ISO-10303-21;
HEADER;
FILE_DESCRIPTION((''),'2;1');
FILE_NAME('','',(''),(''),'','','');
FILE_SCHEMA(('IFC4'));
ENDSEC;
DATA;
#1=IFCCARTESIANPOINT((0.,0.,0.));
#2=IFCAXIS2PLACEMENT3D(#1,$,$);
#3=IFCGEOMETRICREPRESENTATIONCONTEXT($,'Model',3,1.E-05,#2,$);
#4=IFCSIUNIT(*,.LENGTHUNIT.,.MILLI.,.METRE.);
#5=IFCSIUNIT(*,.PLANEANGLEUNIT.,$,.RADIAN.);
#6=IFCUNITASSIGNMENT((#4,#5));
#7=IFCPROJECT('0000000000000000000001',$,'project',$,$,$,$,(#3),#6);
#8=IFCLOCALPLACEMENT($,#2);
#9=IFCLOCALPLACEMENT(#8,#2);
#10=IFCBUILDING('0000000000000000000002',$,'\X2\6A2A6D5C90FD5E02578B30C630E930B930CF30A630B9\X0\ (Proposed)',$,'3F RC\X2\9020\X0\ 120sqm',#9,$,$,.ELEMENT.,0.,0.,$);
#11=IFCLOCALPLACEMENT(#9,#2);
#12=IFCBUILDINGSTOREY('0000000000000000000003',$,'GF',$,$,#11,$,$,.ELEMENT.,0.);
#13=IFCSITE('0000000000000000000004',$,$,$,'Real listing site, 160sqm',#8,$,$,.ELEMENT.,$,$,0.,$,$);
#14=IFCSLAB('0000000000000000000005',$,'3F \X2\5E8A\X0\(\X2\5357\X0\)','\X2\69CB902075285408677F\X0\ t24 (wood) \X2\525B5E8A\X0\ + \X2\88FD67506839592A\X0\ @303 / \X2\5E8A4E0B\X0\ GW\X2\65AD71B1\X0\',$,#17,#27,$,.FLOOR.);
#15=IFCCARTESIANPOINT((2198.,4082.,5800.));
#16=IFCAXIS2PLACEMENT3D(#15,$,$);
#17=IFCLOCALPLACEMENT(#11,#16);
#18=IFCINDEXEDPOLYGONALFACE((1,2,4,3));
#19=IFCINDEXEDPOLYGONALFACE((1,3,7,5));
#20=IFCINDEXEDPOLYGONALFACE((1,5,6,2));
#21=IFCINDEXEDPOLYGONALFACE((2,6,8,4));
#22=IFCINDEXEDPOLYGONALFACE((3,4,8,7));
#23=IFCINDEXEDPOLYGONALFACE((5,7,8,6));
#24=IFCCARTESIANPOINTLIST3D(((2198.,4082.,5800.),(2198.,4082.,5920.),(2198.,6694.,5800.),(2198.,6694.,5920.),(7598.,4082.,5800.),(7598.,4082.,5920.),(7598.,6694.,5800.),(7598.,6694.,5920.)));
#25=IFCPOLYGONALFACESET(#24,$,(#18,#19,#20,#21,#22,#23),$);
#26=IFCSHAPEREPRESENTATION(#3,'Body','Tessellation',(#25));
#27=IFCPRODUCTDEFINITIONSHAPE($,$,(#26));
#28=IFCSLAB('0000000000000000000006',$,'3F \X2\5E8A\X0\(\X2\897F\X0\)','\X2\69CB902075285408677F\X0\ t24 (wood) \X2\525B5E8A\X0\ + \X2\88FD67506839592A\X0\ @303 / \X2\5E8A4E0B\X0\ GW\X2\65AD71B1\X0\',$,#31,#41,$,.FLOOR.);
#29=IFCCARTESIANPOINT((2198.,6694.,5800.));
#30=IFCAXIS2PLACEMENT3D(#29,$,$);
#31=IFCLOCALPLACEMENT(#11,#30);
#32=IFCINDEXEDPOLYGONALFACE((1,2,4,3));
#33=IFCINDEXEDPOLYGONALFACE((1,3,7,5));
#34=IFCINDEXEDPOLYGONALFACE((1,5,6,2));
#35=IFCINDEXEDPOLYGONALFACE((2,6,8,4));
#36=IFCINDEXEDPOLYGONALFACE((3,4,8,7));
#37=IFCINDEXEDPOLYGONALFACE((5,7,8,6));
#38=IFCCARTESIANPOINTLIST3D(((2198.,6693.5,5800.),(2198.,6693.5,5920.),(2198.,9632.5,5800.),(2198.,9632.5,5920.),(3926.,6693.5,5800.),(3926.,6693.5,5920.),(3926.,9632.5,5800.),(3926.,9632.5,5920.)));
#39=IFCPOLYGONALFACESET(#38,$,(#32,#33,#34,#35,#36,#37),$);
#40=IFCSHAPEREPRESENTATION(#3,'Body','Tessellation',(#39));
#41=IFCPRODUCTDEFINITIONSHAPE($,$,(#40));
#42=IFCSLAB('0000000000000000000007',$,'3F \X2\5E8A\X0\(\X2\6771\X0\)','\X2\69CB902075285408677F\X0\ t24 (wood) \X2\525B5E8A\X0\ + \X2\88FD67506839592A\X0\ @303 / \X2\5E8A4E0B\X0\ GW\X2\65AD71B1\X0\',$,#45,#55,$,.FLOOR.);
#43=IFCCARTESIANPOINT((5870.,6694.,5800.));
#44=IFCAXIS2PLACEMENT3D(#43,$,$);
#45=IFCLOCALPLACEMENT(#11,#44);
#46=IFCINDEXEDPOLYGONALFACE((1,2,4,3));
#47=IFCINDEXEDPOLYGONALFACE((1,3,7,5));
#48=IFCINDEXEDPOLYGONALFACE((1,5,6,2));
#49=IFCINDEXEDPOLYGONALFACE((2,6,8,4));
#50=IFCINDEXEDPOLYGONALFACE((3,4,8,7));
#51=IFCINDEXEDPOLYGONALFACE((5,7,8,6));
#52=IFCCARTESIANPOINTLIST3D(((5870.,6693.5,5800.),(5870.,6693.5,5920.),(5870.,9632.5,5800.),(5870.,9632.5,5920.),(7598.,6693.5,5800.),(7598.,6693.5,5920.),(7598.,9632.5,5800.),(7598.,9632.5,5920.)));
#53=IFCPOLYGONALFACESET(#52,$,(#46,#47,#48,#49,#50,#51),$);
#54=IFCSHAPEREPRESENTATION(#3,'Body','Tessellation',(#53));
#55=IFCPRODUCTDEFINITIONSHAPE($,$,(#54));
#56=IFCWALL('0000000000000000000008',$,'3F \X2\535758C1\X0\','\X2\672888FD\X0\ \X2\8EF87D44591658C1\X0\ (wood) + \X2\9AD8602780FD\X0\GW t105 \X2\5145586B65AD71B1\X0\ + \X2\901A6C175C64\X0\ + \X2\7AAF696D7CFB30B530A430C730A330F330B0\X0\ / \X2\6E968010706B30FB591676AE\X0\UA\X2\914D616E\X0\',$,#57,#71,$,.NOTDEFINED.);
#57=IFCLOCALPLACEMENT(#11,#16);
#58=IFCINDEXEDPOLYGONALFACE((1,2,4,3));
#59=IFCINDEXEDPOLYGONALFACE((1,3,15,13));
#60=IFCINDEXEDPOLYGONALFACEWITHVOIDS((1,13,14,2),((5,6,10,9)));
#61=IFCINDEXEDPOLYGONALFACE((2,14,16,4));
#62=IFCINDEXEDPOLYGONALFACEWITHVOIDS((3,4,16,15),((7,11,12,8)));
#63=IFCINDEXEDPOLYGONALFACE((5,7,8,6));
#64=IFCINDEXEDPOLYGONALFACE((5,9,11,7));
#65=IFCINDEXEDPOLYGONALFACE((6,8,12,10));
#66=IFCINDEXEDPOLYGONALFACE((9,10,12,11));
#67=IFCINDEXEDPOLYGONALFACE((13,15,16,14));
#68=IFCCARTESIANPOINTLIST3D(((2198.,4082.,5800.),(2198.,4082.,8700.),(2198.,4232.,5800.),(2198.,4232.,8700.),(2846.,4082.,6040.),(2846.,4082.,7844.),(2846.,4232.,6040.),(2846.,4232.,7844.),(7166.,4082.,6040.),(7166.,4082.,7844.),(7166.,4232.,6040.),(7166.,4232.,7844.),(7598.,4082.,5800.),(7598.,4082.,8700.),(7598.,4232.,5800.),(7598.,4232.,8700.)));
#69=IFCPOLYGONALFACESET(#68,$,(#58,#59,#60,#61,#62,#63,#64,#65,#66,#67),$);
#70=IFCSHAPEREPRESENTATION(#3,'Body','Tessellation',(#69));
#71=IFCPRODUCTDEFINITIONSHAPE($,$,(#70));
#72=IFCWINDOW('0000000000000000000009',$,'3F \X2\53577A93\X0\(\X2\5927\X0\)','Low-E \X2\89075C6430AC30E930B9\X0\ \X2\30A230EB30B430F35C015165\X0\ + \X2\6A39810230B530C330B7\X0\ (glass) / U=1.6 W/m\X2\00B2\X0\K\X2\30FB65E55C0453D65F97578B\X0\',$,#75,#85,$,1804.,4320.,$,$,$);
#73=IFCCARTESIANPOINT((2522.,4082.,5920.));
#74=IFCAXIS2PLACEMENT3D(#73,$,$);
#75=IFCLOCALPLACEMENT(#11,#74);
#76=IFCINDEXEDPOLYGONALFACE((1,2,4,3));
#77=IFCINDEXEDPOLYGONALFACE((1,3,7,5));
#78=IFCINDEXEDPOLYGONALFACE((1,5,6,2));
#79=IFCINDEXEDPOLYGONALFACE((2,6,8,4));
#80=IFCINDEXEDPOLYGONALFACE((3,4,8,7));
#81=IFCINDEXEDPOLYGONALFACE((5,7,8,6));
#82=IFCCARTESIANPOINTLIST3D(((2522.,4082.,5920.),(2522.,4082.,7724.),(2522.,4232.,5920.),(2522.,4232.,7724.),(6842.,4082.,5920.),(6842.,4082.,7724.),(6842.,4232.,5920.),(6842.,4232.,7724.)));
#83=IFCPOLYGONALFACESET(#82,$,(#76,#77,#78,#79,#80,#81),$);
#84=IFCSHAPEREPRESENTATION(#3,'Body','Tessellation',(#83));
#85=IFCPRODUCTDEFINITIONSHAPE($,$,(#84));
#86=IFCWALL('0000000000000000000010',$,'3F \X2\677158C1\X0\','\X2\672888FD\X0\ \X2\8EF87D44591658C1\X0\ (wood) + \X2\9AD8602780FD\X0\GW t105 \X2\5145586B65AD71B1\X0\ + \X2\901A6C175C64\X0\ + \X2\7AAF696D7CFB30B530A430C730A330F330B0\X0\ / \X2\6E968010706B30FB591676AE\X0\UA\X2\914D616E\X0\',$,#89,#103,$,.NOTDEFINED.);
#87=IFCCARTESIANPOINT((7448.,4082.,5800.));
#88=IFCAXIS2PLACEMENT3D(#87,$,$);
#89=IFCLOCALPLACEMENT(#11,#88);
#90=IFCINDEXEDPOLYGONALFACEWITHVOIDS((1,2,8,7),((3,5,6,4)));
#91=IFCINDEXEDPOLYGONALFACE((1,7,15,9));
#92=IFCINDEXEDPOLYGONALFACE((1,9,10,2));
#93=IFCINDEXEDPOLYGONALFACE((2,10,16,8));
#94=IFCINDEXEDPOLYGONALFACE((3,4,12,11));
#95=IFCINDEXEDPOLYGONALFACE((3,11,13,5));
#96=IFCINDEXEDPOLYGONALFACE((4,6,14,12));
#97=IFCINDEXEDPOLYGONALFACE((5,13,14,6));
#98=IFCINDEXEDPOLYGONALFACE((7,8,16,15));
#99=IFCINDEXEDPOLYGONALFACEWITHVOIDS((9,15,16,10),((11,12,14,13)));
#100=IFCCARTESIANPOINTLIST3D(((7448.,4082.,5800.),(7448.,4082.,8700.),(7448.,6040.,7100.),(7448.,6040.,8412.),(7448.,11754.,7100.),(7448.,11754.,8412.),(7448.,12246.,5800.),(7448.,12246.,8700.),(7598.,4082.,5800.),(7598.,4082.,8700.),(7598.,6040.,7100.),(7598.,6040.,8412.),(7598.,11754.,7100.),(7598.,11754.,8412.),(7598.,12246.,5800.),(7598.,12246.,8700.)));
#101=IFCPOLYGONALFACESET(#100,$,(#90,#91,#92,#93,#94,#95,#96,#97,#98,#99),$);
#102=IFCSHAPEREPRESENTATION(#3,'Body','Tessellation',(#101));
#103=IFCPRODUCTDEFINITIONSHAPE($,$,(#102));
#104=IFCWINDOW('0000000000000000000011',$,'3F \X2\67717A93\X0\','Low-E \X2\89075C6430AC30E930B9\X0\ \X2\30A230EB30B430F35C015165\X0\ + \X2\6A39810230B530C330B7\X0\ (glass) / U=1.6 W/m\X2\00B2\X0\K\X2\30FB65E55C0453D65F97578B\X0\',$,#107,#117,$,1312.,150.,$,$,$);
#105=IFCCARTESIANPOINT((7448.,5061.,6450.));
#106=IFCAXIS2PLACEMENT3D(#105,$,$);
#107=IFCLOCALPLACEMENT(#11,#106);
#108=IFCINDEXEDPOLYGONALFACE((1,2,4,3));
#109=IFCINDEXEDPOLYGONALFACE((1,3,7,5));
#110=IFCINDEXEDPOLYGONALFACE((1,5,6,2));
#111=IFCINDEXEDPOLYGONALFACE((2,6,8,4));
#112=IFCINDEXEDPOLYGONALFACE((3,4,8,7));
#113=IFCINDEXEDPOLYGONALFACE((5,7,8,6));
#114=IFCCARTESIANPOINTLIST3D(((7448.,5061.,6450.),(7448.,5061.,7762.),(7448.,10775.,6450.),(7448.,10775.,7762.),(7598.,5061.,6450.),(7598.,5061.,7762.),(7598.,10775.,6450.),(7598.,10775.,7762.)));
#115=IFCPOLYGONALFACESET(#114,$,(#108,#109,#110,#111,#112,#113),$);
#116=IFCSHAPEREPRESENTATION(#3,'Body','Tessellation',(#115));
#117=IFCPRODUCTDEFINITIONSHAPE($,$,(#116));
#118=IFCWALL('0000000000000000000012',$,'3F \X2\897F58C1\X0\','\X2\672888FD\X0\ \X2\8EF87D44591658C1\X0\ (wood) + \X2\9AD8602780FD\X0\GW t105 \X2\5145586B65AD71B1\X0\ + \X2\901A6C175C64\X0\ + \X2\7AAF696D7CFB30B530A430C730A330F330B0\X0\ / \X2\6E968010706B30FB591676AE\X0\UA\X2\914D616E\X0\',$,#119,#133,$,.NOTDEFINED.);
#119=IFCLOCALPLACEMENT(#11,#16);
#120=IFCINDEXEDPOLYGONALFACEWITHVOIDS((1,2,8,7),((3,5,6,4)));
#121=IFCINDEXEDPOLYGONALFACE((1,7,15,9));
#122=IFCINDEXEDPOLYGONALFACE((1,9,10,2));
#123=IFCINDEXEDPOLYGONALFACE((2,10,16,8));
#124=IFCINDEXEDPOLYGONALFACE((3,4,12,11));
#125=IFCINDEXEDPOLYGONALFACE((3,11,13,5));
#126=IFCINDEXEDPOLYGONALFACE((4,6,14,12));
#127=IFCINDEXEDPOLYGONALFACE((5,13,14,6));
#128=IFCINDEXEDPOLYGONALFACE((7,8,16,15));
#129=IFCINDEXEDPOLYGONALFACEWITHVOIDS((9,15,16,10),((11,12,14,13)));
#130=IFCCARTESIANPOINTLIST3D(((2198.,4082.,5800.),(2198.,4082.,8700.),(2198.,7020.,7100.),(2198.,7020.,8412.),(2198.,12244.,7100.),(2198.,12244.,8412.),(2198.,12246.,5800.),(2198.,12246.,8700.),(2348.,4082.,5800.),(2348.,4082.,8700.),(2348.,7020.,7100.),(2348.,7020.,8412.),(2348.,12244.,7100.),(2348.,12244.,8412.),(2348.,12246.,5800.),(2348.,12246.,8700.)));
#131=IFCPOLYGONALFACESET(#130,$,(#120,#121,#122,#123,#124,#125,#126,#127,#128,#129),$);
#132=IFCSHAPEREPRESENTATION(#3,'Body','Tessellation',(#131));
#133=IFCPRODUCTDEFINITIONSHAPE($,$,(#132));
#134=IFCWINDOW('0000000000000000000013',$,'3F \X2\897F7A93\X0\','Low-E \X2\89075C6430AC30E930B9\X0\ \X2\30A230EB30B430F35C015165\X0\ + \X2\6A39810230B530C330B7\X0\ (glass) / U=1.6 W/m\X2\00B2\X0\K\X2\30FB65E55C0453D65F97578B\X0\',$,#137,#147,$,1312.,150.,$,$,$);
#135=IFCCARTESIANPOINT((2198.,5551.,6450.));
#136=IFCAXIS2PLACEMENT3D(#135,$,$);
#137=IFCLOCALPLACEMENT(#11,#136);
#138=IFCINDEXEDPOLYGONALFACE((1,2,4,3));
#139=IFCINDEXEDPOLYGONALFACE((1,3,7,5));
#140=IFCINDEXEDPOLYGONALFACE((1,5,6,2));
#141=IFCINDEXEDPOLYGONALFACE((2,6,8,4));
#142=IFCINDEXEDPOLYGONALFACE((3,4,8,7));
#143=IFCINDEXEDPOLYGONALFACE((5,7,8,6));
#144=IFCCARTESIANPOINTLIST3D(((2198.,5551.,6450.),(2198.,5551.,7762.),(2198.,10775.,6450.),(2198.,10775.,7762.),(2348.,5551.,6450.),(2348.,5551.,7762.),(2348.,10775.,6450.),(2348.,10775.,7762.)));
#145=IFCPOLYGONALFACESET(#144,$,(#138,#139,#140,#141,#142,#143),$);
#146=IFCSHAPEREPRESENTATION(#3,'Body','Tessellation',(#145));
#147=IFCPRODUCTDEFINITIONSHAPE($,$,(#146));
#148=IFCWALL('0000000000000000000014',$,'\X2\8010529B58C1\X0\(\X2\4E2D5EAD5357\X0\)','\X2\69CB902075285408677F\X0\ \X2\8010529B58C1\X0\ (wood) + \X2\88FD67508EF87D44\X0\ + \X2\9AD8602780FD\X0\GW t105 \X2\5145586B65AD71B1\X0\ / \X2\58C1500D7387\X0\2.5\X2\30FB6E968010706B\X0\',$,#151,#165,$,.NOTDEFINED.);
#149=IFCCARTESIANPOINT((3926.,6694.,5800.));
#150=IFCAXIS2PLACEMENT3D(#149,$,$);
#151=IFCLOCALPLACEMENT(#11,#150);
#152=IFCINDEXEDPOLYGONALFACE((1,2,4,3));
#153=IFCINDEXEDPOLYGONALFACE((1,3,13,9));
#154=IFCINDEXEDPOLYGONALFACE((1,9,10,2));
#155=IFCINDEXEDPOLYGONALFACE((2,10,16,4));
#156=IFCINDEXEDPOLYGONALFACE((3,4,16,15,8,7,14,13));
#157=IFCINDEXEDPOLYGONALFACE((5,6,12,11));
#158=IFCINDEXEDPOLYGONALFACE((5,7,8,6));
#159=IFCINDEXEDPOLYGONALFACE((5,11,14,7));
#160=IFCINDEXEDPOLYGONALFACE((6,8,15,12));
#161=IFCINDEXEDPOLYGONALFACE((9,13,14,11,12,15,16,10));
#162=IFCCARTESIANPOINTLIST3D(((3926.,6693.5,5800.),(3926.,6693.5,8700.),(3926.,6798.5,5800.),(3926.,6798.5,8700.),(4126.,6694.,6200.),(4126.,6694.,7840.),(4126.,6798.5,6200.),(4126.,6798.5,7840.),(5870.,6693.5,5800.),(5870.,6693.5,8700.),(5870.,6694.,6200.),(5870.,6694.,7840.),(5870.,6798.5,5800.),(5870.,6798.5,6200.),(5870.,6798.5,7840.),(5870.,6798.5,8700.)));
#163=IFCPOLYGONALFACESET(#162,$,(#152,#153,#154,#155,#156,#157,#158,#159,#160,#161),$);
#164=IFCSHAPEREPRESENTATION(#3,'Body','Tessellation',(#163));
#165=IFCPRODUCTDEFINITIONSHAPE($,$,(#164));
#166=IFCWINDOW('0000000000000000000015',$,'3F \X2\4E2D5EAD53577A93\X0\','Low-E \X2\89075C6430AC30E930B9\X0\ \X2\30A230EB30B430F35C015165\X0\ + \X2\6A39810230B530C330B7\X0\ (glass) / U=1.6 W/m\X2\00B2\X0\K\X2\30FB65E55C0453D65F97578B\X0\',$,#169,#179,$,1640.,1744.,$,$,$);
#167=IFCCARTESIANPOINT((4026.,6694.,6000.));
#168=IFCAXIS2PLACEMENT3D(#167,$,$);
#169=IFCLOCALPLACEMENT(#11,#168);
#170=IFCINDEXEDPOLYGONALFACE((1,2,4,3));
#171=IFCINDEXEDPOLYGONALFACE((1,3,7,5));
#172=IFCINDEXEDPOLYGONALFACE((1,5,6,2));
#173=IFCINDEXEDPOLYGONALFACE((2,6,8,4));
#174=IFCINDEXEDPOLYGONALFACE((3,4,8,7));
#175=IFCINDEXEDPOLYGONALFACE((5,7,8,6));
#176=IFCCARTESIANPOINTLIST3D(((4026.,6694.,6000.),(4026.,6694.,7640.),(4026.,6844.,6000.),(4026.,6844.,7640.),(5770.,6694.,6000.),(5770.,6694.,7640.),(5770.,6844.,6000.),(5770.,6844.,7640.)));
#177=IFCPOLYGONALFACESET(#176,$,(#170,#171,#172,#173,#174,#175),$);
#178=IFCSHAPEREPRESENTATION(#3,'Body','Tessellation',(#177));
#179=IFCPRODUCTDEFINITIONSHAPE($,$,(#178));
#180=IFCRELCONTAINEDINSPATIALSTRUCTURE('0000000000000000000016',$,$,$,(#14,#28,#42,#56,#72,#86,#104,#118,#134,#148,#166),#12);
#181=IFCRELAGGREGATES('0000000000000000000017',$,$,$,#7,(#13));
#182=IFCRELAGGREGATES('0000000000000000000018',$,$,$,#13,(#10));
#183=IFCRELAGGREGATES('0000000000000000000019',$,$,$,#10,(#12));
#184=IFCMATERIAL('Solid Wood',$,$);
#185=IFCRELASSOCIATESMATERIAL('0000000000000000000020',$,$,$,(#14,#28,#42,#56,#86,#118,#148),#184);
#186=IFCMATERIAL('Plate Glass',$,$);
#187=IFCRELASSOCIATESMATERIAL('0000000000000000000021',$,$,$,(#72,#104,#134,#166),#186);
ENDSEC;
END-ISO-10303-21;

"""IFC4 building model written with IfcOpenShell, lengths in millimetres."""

from ifc_helpers import new_model, si_unit, frame, frame_2d, origin, place, context, project, spatial, rectangle, extrude, material, element, fill, save


model = new_model("IFC4")

# Units and contexts
model_context = context("Model", 3, precision=1e-05, world=origin())
ifc_project = project(units=[si_unit("LENGTHUNIT", "METRE", prefix="MILLI"), si_unit("PLANEANGLEUNIT", "RADIAN")], contexts=[model_context])

# Site, building, storey
site_placement = place(None, origin())
site = spatial("IfcSite", under=ifc_project, at=site_placement, ObjectType="Real listing site, 160sqm", CompositionType="ELEMENT", RefElevation=0.0)
building_placement = place(site_placement, origin())
building = spatial("IfcBuilding", under=site, at=building_placement, Name="横浜都市型テラスハウス (Proposed)", ObjectType="3F RC造 120sqm", CompositionType="ELEMENT", ElevationOfRefHeight=0.0, ElevationOfTerrain=0.0)
storey_placement = place(building_placement, origin())
storey = spatial("IfcBuildingStorey", under=building, at=storey_placement, Name="GF", CompositionType="ELEMENT", Elevation=0.0)

# Slabs
ifc_material_1 = material(Name="Solid Wood")
slab_1_placement = place(storey_placement, frame((2198.0, 4082.0, 5800.0)))
element("IfcSlab", 1, at=slab_1_placement, inside=storey, material=ifc_material_1, Name="3F 床(南)", Description="構造用合板 t24 (wood) 剛床 + 製材根太 @303 / 床下 GW断熱", PredefinedType="FLOOR", context=model_context, shape_type="SweptSolid", body=[
    extrude(rectangle(XDim=5400.0, YDim=2612.0, at=frame_2d((2700.0, 1306.0))), frame((2198.0, 4082.0, 5800.0)), (0.0, 0.0, 1.0), 120.0),
])
slab_2_placement = place(storey_placement, frame((2198.0, 6694.0, 5800.0)))
element("IfcSlab", 2, at=slab_2_placement, inside=storey, material=ifc_material_1, Name="3F 床(西)", Description="構造用合板 t24 (wood) 剛床 + 製材根太 @303 / 床下 GW断熱", PredefinedType="FLOOR", context=model_context, shape_type="SweptSolid", body=[
    extrude(rectangle(XDim=1728.0, YDim=2939.0, at=frame_2d((864.0, 1469.0))), frame((2198.0, 6694.0, 5800.0)), (0.0, 0.0, 1.0), 120.0),
])
slab_3_placement = place(storey_placement, frame((5870.0, 6694.0, 5800.0)))
element("IfcSlab", 3, at=slab_3_placement, inside=storey, material=ifc_material_1, Name="3F 床(東)", Description="構造用合板 t24 (wood) 剛床 + 製材根太 @303 / 床下 GW断熱", PredefinedType="FLOOR", context=model_context, shape_type="SweptSolid", body=[
    extrude(rectangle(XDim=1728.0, YDim=2939.0, at=frame_2d((864.0, 1469.0))), frame((5870.0, 6694.0, 5800.0)), (0.0, 0.0, 1.0), 120.0),
])

# Walls, openings, windows
wall_1_placement = place(storey_placement, frame((2198.0, 4082.0, 5800.0)))
wall_1 = element("IfcWall", 4, at=wall_1_placement, inside=storey, material=ifc_material_1, Name="3F 南壁", Description="木製 軸組外壁 (wood) + 高性能GW t105 充填断熱 + 通気層 + 窯業系サイディング / 準耐火・外皮UA配慮", PredefinedType="NOTDEFINED", context=model_context, shape_type="SweptSolid", body=[
    extrude(rectangle(XDim=5400.0, YDim=150.0, at=frame_2d((2700.0, 75.0))), frame((2198.0, 4082.0, 5800.0)), (0.0, 0.0, 1.0), 2900.0),
])
opening_1_placement = place(storey_placement, frame((2522.0, 4082.0, 5920.0)))
opening_1 = element("IfcOpeningElement", 5, at=opening_1_placement, cuts=wall_1, PredefinedType="NOTDEFINED", context=model_context, shape_type="SweptSolid", body=[
    extrude(rectangle(XDim=4320.0, YDim=150.0, at=frame_2d((2160.0, 75.0))), frame((2522.0, 4082.0, 5920.0)), (0.0, 0.0, 1.0), 1804.0),
])
ifc_material_2 = material(Name="Plate Glass")
window_1_placement = place(storey_placement, frame((2522.0, 4082.0, 5920.0)))
window_1 = element("IfcWindow", 6, at=window_1_placement, inside=storey, material=ifc_material_2, Name="3F 南窓(大)", Description="Low-E 複層ガラス アルゴン封入 + 樹脂サッシ (glass) / U=1.6 W/m²K・日射取得型", OverallHeight=1804.0, OverallWidth=4320.0, context=model_context, shape_type="SweptSolid", body=[
    extrude(rectangle(XDim=4320.0, YDim=150.0, at=frame_2d((2160.0, 75.0))), frame((2522.0, 4082.0, 5920.0)), (0.0, 0.0, 1.0), 1804.0),
])
fill(opening_1, window_1)
wall_2_placement = place(storey_placement, frame((7448.0, 4082.0, 5800.0)))
wall_2 = element("IfcWall", 7, at=wall_2_placement, inside=storey, material=ifc_material_1, Name="3F 東壁", Description="木製 軸組外壁 (wood) + 高性能GW t105 充填断熱 + 通気層 + 窯業系サイディング / 準耐火・外皮UA配慮", PredefinedType="NOTDEFINED", context=model_context, shape_type="SweptSolid", body=[
    extrude(rectangle(XDim=150.0, YDim=8164.0, at=frame_2d((75.0, 4082.0))), frame((7448.0, 4082.0, 5800.0)), (0.0, 0.0, 1.0), 2900.0),
])
opening_2_placement = place(storey_placement, frame((7448.0, 5061.0, 6450.0)))
opening_2 = element("IfcOpeningElement", 8, at=opening_2_placement, cuts=wall_2, PredefinedType="NOTDEFINED", context=model_context, shape_type="SweptSolid", body=[
    extrude(rectangle(XDim=150.0, YDim=5714.0, at=frame_2d((75.0, 2857.0))), frame((7448.0, 5061.0, 6450.0)), (0.0, 0.0, 1.0), 1312.0),
])
window_2_placement = place(storey_placement, frame((7448.0, 5061.0, 6450.0)))
window_2 = element("IfcWindow", 9, at=window_2_placement, inside=storey, material=ifc_material_2, Name="3F 東窓", Description="Low-E 複層ガラス アルゴン封入 + 樹脂サッシ (glass) / U=1.6 W/m²K・日射取得型", OverallHeight=1312.0, OverallWidth=150.0, context=model_context, shape_type="SweptSolid", body=[
    extrude(rectangle(XDim=150.0, YDim=5714.0, at=frame_2d((75.0, 2857.0))), frame((7448.0, 5061.0, 6450.0)), (0.0, 0.0, 1.0), 1312.0),
])
fill(opening_2, window_2)
wall_3_placement = place(storey_placement, frame((2198.0, 4082.0, 5800.0)))
wall_3 = element("IfcWall", 10, at=wall_3_placement, inside=storey, material=ifc_material_1, Name="3F 西壁", Description="木製 軸組外壁 (wood) + 高性能GW t105 充填断熱 + 通気層 + 窯業系サイディング / 準耐火・外皮UA配慮", PredefinedType="NOTDEFINED", context=model_context, shape_type="SweptSolid", body=[
    extrude(rectangle(XDim=150.0, YDim=8164.0, at=frame_2d((75.0, 4082.0))), frame((2198.0, 4082.0, 5800.0)), (0.0, 0.0, 1.0), 2900.0),
])
opening_3_placement = place(storey_placement, frame((2198.0, 5551.0, 6450.0)))
opening_3 = element("IfcOpeningElement", 11, at=opening_3_placement, cuts=wall_3, PredefinedType="NOTDEFINED", context=model_context, shape_type="SweptSolid", body=[
    extrude(rectangle(XDim=150.0, YDim=5224.0, at=frame_2d((75.0, 2612.0))), frame((2198.0, 5551.0, 6450.0)), (0.0, 0.0, 1.0), 1312.0),
])
window_3_placement = place(storey_placement, frame((2198.0, 5551.0, 6450.0)))
window_3 = element("IfcWindow", 12, at=window_3_placement, inside=storey, material=ifc_material_2, Name="3F 西窓", Description="Low-E 複層ガラス アルゴン封入 + 樹脂サッシ (glass) / U=1.6 W/m²K・日射取得型", OverallHeight=1312.0, OverallWidth=150.0, context=model_context, shape_type="SweptSolid", body=[
    extrude(rectangle(XDim=150.0, YDim=5224.0, at=frame_2d((75.0, 2612.0))), frame((2198.0, 5551.0, 6450.0)), (0.0, 0.0, 1.0), 1312.0),
])
fill(opening_3, window_3)
wall_4_placement = place(storey_placement, frame((3926.0, 6694.0, 5800.0)))
wall_4 = element("IfcWall", 13, at=wall_4_placement, inside=storey, material=ifc_material_1, Name="耐力壁(中庭南)", Description="構造用合板 耐力壁 (wood) + 製材軸組 + 高性能GW t105 充填断熱 / 壁倍率2.5・準耐火", PredefinedType="NOTDEFINED", context=model_context, shape_type="SweptSolid", body=[
    extrude(rectangle(XDim=1944.0, YDim=105.0, at=frame_2d((972.0, 52.0))), frame((3926.0, 6694.0, 5800.0)), (0.0, 0.0, 1.0), 2900.0),
])
opening_4_placement = place(storey_placement, frame((4026.0, 6694.0, 6000.0)))
opening_4 = element("IfcOpeningElement", 14, at=opening_4_placement, cuts=wall_4, PredefinedType="NOTDEFINED", context=model_context, shape_type="SweptSolid", body=[
    extrude(rectangle(XDim=1744.0, YDim=150.0, at=frame_2d((872.0, 75.0))), frame((4026.0, 6694.0, 6000.0)), (0.0, 0.0, 1.0), 1640.0),
])
window_4_placement = place(storey_placement, frame((4026.0, 6694.0, 6000.0)))
window_4 = element("IfcWindow", 15, at=window_4_placement, inside=storey, material=ifc_material_2, Name="3F 中庭南窓", Description="Low-E 複層ガラス アルゴン封入 + 樹脂サッシ (glass) / U=1.6 W/m²K・日射取得型", OverallHeight=1640.0, OverallWidth=1744.0, context=model_context, shape_type="SweptSolid", body=[
    extrude(rectangle(XDim=1744.0, YDim=150.0, at=frame_2d((872.0, 75.0))), frame((4026.0, 6694.0, 6000.0)), (0.0, 0.0, 1.0), 1640.0),
])
fill(opening_4, window_4)

save(model, "model.ifc")
